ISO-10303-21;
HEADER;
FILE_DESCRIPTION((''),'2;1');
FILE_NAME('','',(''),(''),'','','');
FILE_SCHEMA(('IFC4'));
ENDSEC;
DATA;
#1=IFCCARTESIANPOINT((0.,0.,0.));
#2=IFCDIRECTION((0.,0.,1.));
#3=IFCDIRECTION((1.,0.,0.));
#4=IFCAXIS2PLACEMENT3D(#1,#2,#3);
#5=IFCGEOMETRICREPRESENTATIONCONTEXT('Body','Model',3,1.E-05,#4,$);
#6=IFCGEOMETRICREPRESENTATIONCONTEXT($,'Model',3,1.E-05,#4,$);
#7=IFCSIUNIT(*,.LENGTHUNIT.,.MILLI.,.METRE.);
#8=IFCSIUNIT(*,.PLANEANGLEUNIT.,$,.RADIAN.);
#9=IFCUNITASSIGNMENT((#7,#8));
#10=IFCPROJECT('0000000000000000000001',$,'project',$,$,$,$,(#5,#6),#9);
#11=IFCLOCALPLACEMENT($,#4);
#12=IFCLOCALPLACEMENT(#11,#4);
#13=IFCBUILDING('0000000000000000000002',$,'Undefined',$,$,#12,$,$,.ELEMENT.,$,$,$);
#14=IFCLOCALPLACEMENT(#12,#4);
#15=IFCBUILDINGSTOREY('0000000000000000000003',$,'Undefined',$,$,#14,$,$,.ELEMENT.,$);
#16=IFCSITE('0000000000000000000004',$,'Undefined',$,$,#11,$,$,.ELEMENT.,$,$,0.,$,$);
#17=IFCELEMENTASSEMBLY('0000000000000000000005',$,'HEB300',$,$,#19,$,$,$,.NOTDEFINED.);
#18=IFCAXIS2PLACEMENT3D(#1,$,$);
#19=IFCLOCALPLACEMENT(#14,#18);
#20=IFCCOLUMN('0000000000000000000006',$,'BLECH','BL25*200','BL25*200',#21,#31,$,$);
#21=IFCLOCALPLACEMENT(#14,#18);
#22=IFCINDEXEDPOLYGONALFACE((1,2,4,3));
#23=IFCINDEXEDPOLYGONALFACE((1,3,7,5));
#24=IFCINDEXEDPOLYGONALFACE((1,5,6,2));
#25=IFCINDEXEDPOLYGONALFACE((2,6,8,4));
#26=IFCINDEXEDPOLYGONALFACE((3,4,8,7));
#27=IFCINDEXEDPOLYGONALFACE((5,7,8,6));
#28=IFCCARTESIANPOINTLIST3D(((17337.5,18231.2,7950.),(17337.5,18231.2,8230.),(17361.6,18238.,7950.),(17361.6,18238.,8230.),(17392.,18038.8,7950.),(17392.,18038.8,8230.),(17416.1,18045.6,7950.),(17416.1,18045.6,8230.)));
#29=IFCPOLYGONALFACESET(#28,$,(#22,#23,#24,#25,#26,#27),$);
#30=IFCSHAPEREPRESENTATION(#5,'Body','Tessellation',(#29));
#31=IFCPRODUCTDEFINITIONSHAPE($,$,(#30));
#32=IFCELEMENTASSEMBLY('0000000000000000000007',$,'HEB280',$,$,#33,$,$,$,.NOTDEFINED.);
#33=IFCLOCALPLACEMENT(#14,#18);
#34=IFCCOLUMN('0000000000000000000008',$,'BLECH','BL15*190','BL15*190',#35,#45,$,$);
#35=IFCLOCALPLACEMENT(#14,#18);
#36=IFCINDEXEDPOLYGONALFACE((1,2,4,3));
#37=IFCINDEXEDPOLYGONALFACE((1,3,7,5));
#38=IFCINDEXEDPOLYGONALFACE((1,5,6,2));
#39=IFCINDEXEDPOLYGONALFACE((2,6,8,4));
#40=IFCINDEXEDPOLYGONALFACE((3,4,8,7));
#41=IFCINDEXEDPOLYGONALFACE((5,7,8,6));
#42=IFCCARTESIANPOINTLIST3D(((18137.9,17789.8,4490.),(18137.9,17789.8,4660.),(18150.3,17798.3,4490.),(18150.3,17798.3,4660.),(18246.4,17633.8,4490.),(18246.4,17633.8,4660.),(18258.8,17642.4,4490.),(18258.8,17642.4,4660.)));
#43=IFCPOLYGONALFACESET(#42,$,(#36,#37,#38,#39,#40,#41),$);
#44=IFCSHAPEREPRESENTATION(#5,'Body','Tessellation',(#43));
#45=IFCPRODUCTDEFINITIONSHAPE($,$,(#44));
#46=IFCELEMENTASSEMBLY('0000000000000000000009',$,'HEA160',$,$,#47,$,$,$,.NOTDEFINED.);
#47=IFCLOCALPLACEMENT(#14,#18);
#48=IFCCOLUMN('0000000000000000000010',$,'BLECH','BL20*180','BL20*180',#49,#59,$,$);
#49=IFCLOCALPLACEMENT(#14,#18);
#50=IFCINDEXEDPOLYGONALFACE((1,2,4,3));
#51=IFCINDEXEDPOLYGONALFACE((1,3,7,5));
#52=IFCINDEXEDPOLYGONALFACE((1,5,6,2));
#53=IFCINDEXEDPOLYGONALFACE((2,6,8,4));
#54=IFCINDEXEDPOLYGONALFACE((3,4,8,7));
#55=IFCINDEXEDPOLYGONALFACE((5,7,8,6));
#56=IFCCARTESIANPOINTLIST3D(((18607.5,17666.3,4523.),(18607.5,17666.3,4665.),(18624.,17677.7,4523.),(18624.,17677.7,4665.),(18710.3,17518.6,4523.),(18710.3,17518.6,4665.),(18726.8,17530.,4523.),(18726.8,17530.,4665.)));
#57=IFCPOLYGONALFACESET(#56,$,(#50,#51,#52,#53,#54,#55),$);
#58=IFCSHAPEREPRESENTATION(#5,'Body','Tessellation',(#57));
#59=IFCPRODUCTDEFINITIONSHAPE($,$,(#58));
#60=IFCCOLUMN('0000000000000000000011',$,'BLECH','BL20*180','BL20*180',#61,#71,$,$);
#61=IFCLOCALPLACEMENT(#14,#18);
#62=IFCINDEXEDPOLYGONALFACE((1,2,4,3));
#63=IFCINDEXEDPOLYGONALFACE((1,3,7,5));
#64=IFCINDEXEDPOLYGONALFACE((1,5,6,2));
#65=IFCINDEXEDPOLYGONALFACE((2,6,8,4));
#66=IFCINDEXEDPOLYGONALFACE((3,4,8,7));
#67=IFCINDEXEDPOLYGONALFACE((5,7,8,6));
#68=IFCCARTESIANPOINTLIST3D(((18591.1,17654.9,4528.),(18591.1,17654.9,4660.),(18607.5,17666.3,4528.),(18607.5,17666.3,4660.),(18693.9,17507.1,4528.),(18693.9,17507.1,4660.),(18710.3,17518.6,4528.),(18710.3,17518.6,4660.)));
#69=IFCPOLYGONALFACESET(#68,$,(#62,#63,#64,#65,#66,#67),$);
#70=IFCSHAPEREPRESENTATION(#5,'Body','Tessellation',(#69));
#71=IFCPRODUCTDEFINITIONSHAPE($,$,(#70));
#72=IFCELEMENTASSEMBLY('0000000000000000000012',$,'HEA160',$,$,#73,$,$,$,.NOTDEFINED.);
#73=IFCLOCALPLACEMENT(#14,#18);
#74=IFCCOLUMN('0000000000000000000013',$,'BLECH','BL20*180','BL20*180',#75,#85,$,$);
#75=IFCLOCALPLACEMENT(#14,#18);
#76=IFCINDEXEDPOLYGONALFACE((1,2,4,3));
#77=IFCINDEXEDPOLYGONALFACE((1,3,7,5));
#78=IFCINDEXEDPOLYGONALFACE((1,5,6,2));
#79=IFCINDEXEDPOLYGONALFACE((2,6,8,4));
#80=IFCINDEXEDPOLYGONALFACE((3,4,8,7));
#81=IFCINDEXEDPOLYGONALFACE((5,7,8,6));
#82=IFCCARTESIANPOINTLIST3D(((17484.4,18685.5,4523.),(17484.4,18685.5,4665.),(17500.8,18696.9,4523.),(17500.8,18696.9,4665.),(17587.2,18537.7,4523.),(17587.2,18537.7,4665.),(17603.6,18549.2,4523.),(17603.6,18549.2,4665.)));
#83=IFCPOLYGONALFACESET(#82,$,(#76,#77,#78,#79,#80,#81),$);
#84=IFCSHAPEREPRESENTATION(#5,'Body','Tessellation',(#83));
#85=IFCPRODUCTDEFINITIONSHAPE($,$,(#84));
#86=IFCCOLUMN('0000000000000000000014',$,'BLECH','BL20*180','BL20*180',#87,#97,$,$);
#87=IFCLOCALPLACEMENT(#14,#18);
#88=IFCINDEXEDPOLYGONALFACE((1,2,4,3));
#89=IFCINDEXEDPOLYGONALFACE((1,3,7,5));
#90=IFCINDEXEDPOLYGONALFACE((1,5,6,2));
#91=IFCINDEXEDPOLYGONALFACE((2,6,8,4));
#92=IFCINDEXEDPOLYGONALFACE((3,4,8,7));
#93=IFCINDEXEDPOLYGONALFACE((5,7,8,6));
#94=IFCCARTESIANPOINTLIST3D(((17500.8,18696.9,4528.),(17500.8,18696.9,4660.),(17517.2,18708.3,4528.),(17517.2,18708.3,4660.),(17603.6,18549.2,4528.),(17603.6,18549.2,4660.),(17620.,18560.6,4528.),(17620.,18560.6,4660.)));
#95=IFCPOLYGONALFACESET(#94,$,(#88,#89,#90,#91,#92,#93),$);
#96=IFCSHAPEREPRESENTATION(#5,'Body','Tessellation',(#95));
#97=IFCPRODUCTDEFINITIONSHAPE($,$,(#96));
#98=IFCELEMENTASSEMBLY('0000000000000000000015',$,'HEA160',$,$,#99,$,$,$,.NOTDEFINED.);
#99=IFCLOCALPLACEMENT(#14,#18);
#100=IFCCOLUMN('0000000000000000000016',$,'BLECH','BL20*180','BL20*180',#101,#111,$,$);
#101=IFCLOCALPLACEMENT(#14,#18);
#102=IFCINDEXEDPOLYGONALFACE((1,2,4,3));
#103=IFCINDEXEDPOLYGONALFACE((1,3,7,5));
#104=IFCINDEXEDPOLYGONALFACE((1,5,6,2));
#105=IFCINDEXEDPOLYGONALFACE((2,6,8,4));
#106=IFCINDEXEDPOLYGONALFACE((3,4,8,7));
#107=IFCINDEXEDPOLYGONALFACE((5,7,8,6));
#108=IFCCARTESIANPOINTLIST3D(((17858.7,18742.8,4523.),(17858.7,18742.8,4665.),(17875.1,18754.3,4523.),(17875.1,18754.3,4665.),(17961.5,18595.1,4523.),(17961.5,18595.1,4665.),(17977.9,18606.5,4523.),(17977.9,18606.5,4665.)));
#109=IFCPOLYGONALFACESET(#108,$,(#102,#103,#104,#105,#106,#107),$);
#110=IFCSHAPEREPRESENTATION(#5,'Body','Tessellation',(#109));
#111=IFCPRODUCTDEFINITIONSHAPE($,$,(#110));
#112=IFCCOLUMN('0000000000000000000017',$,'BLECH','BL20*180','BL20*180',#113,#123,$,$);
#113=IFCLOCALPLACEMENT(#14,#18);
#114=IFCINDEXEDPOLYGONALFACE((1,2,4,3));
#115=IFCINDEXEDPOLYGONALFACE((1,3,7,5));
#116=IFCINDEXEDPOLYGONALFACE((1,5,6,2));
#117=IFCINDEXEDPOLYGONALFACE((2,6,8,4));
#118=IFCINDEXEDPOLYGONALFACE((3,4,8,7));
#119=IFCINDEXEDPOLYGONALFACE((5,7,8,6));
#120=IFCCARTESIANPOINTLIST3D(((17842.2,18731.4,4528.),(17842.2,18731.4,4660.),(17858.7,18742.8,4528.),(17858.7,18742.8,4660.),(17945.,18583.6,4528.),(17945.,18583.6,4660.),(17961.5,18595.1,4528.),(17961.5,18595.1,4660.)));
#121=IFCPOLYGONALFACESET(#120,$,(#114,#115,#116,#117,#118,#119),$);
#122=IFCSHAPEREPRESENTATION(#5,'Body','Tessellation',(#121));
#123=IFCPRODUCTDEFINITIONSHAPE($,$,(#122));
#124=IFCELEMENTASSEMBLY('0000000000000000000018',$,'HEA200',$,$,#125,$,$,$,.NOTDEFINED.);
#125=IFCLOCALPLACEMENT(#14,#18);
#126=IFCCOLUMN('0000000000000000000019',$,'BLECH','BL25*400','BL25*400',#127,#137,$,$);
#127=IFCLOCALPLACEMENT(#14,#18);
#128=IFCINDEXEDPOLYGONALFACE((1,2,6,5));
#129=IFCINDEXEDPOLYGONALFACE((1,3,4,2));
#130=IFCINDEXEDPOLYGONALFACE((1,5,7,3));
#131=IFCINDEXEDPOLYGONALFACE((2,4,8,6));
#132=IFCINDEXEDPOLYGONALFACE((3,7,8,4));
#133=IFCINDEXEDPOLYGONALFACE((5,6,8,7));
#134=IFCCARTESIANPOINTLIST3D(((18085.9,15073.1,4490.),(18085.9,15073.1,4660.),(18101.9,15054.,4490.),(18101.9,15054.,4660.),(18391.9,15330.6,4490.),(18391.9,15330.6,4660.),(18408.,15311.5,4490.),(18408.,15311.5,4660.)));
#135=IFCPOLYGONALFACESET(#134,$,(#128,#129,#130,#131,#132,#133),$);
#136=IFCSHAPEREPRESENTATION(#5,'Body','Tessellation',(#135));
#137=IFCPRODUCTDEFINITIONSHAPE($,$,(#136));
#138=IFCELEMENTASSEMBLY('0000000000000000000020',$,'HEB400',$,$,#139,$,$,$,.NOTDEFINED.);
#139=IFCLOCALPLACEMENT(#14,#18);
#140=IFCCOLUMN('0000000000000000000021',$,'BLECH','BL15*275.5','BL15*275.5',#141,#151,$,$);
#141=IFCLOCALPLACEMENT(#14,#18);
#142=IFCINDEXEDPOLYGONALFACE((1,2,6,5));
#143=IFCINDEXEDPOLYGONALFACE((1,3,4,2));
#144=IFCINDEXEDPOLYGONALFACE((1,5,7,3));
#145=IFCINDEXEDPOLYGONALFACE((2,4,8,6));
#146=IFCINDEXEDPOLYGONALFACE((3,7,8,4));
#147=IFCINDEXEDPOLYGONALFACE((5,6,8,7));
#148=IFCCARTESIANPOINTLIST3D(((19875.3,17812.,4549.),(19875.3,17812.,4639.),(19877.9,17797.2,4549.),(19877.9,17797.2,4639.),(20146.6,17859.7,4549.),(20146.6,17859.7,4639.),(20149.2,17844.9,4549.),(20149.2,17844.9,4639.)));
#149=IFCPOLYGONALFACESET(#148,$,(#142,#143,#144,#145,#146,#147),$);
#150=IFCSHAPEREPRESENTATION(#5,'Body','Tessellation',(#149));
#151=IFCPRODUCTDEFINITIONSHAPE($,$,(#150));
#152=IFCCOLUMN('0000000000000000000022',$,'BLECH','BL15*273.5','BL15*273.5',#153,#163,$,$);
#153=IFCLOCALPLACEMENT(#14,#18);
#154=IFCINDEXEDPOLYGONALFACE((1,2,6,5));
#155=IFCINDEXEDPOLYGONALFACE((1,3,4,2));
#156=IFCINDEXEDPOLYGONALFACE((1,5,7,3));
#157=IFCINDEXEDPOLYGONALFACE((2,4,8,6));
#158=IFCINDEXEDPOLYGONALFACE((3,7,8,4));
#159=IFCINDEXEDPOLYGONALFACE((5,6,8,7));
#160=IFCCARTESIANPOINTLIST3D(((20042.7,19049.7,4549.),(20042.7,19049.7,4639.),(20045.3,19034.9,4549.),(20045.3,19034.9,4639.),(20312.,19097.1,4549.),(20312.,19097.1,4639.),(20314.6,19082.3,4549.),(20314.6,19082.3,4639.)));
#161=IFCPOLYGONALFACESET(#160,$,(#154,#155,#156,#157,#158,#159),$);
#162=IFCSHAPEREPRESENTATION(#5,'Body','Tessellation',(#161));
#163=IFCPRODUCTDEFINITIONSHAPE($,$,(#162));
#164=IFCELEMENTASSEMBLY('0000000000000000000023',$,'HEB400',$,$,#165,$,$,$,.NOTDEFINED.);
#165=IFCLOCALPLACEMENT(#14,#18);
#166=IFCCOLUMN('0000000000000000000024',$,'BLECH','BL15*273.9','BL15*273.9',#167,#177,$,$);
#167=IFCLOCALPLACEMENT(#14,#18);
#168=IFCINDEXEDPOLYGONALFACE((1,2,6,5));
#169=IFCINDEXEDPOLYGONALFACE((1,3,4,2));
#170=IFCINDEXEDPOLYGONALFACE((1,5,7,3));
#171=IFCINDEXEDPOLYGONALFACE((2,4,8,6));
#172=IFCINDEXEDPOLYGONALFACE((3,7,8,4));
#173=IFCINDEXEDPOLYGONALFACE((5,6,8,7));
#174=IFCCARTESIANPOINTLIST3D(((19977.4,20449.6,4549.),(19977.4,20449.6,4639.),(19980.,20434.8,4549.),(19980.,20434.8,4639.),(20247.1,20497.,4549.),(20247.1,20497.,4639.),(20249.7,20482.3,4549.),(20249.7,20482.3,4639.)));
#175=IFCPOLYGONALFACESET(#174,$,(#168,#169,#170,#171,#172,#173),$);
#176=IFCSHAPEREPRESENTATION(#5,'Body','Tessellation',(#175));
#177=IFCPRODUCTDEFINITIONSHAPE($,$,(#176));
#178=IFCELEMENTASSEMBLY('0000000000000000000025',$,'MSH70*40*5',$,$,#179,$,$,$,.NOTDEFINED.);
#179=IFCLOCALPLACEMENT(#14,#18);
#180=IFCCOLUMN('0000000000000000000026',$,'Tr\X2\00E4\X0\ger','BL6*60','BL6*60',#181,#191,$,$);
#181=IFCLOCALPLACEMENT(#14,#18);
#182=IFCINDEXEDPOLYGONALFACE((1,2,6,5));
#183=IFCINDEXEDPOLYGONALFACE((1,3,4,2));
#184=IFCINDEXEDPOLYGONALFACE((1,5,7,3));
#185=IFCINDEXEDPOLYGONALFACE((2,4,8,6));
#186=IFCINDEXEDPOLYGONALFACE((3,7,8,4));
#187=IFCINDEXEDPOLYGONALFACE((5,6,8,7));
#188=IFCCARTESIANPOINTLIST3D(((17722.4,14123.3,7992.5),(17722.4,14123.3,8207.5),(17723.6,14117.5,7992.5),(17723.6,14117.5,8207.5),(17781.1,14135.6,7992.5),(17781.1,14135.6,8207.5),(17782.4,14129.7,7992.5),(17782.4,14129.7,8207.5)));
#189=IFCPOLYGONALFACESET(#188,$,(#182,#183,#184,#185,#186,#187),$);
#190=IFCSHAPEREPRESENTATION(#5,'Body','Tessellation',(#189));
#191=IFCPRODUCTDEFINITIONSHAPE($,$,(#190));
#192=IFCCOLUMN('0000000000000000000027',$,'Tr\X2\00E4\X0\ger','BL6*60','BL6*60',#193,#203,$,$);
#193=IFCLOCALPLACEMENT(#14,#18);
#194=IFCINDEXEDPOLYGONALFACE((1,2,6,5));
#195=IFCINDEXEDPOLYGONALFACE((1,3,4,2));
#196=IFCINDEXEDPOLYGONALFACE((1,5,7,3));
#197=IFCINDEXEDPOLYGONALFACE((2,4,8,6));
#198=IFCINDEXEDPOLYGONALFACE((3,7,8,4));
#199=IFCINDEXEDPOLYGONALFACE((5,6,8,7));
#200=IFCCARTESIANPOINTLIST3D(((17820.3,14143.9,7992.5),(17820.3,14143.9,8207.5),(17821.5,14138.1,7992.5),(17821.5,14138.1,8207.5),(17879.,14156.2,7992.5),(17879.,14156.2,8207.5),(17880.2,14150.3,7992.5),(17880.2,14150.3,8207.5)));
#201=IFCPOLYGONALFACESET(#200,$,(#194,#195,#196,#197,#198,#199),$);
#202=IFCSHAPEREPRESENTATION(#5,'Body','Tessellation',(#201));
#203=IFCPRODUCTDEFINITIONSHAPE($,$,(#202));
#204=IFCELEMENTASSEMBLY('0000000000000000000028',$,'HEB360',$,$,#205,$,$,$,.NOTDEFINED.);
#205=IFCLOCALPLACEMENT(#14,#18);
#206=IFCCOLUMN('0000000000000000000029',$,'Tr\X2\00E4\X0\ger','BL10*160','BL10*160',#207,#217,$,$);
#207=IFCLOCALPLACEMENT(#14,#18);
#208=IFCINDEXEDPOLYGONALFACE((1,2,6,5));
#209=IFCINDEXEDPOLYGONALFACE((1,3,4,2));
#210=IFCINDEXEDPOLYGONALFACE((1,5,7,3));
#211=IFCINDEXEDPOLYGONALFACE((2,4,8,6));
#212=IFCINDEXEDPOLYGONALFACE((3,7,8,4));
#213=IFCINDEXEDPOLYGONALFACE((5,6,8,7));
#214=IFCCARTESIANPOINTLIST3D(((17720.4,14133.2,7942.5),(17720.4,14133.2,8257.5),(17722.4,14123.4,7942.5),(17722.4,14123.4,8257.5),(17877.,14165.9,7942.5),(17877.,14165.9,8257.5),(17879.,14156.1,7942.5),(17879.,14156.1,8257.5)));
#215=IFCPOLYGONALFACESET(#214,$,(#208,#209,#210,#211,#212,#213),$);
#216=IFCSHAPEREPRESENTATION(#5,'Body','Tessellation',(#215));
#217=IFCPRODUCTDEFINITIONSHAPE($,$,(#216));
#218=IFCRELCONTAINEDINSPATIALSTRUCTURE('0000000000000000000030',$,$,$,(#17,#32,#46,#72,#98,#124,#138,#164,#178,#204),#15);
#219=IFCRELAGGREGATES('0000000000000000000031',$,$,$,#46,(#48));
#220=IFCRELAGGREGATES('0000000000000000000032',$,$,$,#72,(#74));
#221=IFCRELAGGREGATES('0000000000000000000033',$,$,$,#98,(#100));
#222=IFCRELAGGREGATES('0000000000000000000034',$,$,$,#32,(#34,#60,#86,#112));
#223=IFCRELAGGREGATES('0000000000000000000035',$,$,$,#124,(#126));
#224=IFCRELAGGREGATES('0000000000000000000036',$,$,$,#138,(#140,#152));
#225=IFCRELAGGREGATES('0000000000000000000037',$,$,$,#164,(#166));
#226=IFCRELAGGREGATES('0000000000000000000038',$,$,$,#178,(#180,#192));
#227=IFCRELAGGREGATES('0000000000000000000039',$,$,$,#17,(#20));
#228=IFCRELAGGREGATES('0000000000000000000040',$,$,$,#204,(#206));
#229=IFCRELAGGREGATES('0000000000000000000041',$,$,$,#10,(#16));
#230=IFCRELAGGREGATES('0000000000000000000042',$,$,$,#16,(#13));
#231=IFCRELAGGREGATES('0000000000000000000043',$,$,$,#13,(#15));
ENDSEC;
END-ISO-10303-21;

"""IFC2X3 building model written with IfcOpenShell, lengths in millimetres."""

from ifc_helpers import new_model, si_unit, frame, origin_with_axes, origin_2d_with_axis, place, context, project, spatial, rectangle, extrude, element, aggregate, save


model = new_model("IFC2X3")

# Units and contexts
model_context_1 = context("Model", 3, precision=1e-05, world=origin_with_axes(), identifier="Body")
model_context_2 = context("Model", 3, precision=1e-05, world=origin_with_axes())
ifc_project = project(units=[si_unit("LENGTHUNIT", "METRE", prefix="MILLI"), si_unit("PLANEANGLEUNIT", "RADIAN")], contexts=[model_context_1, model_context_2])

# Site, building, storey
site_placement = place(None, origin_with_axes())
site = spatial("IfcSite", under=ifc_project, at=site_placement, Name="Undefined", CompositionType="ELEMENT", RefElevation=0.0)
building_placement = place(site_placement, origin_with_axes())
building = spatial("IfcBuilding", under=site, at=building_placement, Name="Undefined", CompositionType="ELEMENT")
storey_placement = place(building_placement, origin_with_axes())
storey = spatial("IfcBuildingStorey", under=building, at=storey_placement, Name="Undefined", CompositionType="ELEMENT")

# Element assemblies, columns
assembly_1 = element("IfcElementAssembly", 1, inside=storey, Name="HEB300", PredefinedType="NOTDEFINED")
column_1_placement = place(storey_placement, frame((17376.8, 18138.4, 7950.0), z_axis=(0.0, 0.0, 1.0), x_axis=(1.0, 0.0, 0.0)))
column_1 = element("IfcColumn", 2, at=column_1_placement, Name="BLECH", Description="BL25*200", ObjectType="BL25*200", context=model_context_1, shape_type="SweptSolid", body=[
    extrude(rectangle(XDim=25.0, YDim=200.0, at=origin_2d_with_axis()), frame((0.0, 0.0, 280.0), z_axis=(0.0, 0.0, -1.0), x_axis=(0.96217, 0.272448, 0.0)), (0.0, 0.0, 1.0), 280.0),
])
assembly_2 = element("IfcElementAssembly", 3, inside=storey, Name="HEB280", PredefinedType="NOTDEFINED")
column_2_placement = place(storey_placement, frame((18198.4, 17716.1, 4490.0), z_axis=(0.0, 0.0, 1.0), x_axis=(1.0, 0.0, 0.0)))
column_2 = element("IfcColumn", 4, at=column_2_placement, Name="BLECH", Description="BL15*190", ObjectType="BL15*190", context=model_context_1, shape_type="SweptSolid", body=[
    extrude(rectangle(XDim=15.0, YDim=190.0, at=origin_2d_with_axis()), frame((0.0, 0.0, 170.0), z_axis=(0.0, 0.0, -1.0), x_axis=(-0.820902, -0.571069, 0.0)), (0.0, 0.0, 1.0), 170.0),
])
assembly_3 = element("IfcElementAssembly", 5, inside=storey, Name="HEA160", PredefinedType="NOTDEFINED")
column_3_placement = place(storey_placement, frame((18667.2, 17598.2, 4523.0), z_axis=(0.0, 0.0, 1.0), x_axis=(1.0, 0.0, 0.0)))
column_3 = element("IfcColumn", 6, at=column_3_placement, Name="BLECH", Description="BL20*180", ObjectType="BL20*180", context=model_context_1, shape_type="SweptSolid", body=[
    extrude(rectangle(XDim=20.0, YDim=180.0, at=origin_2d_with_axis()), frame((0.0, 0.0, 142.0), z_axis=(0.0, 0.0, -1.0), x_axis=(0.820902, 0.571069, 0.0)), (0.0, 0.0, 1.0), 142.0),
])
aggregate(assembly_3, [column_3])

# Column
column_4_placement = place(storey_placement, frame((18650.7, 17586.7, 4528.0), z_axis=(0.0, 0.0, 1.0), x_axis=(1.0, 0.0, 0.0)))
column_4 = element("IfcColumn", 7, at=column_4_placement, Name="BLECH", Description="BL20*180", ObjectType="BL20*180", context=model_context_1, shape_type="SweptSolid", body=[
    extrude(rectangle(XDim=20.0, YDim=180.0, at=origin_2d_with_axis()), frame((0.0, 0.0, 132.0), z_axis=(0.0, 0.0, -1.0), x_axis=(0.820902, 0.571069, 0.0)), (0.0, 0.0, 1.0), 132.0),
])

# Element assembly, column
assembly_4 = element("IfcElementAssembly", 8, inside=storey, Name="HEA160", PredefinedType="NOTDEFINED")
column_5_placement = place(storey_placement, frame((17544.0, 18617.3, 4523.0), z_axis=(0.0, 0.0, 1.0), x_axis=(1.0, 0.0, 0.0)))
column_5 = element("IfcColumn", 9, at=column_5_placement, Name="BLECH", Description="BL20*180", ObjectType="BL20*180", context=model_context_1, shape_type="SweptSolid", body=[
    extrude(rectangle(XDim=20.0, YDim=180.0, at=origin_2d_with_axis()), frame((0.0, 0.0, 142.0), z_axis=(0.0, 0.0, -1.0), x_axis=(-0.820902, -0.571069, 0.0)), (0.0, 0.0, 1.0), 142.0),
])
aggregate(assembly_4, [column_5])

# Column
column_6_placement = place(storey_placement, frame((17560.4, 18628.8, 4528.0), z_axis=(0.0, 0.0, 1.0), x_axis=(1.0, 0.0, 0.0)))
column_6 = element("IfcColumn", 10, at=column_6_placement, Name="BLECH", Description="BL20*180", ObjectType="BL20*180", context=model_context_1, shape_type="SweptSolid", body=[
    extrude(rectangle(XDim=20.0, YDim=180.0, at=origin_2d_with_axis()), frame((0.0, 0.0, 132.0), z_axis=(0.0, 0.0, -1.0), x_axis=(-0.820902, -0.571069, 0.0)), (0.0, 0.0, 1.0), 132.0),
])

# Element assembly, column
assembly_5 = element("IfcElementAssembly", 11, inside=storey, Name="HEA160", PredefinedType="NOTDEFINED")
column_7_placement = place(storey_placement, frame((17918.3, 18674.7, 4523.0), z_axis=(0.0, 0.0, 1.0), x_axis=(1.0, 0.0, 0.0)))
column_7 = element("IfcColumn", 12, at=column_7_placement, Name="BLECH", Description="BL20*180", ObjectType="BL20*180", context=model_context_1, shape_type="SweptSolid", body=[
    extrude(rectangle(XDim=20.0, YDim=180.0, at=origin_2d_with_axis()), frame((0.0, 0.0, 142.0), z_axis=(0.0, 0.0, -1.0), x_axis=(0.820902, 0.571069, 0.0)), (0.0, 0.0, 1.0), 142.0),
])
aggregate(assembly_5, [column_7])

# Column
column_8_placement = place(storey_placement, frame((17901.9, 18663.2, 4528.0), z_axis=(0.0, 0.0, 1.0), x_axis=(1.0, 0.0, 0.0)))
column_8 = element("IfcColumn", 13, at=column_8_placement, Name="BLECH", Description="BL20*180", ObjectType="BL20*180", context=model_context_1, shape_type="SweptSolid", body=[
    extrude(rectangle(XDim=20.0, YDim=180.0, at=origin_2d_with_axis()), frame((0.0, 0.0, 132.0), z_axis=(0.0, 0.0, -1.0), x_axis=(0.820902, 0.571069, 0.0)), (0.0, 0.0, 1.0), 132.0),
])
aggregate(assembly_2, [column_2, column_4, column_6, column_8])

# Element assembly, column
assembly_6 = element("IfcElementAssembly", 14, inside=storey, Name="HEA200", PredefinedType="NOTDEFINED")
column_9_placement = place(storey_placement, frame((18246.9, 15192.3, 4490.0), z_axis=(0.0, 0.0, 1.0), x_axis=(1.0, 0.0, 0.0)))
column_9 = element("IfcColumn", 15, at=column_9_placement, Name="BLECH", Description="BL25*400", ObjectType="BL25*400", context=model_context_1, shape_type="SweptSolid", body=[
    extrude(rectangle(XDim=25.0, YDim=400.0, at=origin_2d_with_axis()), frame((0.0, 0.0, 170.0), z_axis=(0.0, 0.0, -1.0), x_axis=(-0.643784, 0.765207, 0.0)), (0.0, 0.0, 1.0), 170.0),
])
aggregate(assembly_6, [column_9])

# Element assembly, columns
assembly_7 = element("IfcElementAssembly", 16, inside=storey, Name="HEB400", PredefinedType="NOTDEFINED")
column_10_placement = place(storey_placement, frame((20012.2, 17828.5, 4549.0), z_axis=(0.0, 0.0, 1.0), x_axis=(1.0, 0.0, 0.0)))
column_10 = element("IfcColumn", 17, at=column_10_placement, Name="BLECH", Description="BL15*275.5", ObjectType="BL15*275.5", context=model_context_1, shape_type="SweptSolid", body=[
    extrude(rectangle(XDim=15.0, YDim=275.5, at=origin_2d_with_axis()), frame((0.0, 0.0, 90.0), z_axis=(0.0, 0.0, -1.0), x_axis=(-0.173304, 0.984868, 0.0)), (0.0, 0.0, 1.0), 90.0),
])
column_11_placement = place(storey_placement, frame((20178.6, 19066.0, 4549.0), z_axis=(0.0, 0.0, 1.0), x_axis=(1.0, 0.0, 0.0)))
column_11 = element("IfcColumn", 18, at=column_11_placement, Name="BLECH", Description="BL15*273.5", ObjectType="BL15*273.5", context=model_context_1, shape_type="SweptSolid", body=[
    extrude(rectangle(XDim=15.0, YDim=273.5, at=origin_2d_with_axis()), frame((0.0, 0.0, 90.0), z_axis=(0.0, 0.0, -1.0), x_axis=(-0.173304, 0.984868, 0.0)), (0.0, 0.0, 1.0), 90.0),
])
aggregate(assembly_7, [column_10, column_11])

# Element assembly, column
assembly_8 = element("IfcElementAssembly", 19, inside=storey, Name="HEB400", PredefinedType="NOTDEFINED")
column_12_placement = place(storey_placement, frame((20113.6, 20465.9, 4549.0), z_axis=(0.0, 0.0, 1.0), x_axis=(1.0, 0.0, 0.0)))
column_12 = element("IfcColumn", 20, at=column_12_placement, Name="BLECH", Description="BL15*273.9", ObjectType="BL15*273.9", context=model_context_1, shape_type="SweptSolid", body=[
    extrude(rectangle(XDim=15.0, YDim=273.9, at=origin_2d_with_axis()), frame((0.0, 0.0, 90.0), z_axis=(0.0, 0.0, -1.0), x_axis=(-0.173304, 0.984868, 0.0)), (0.0, 0.0, 1.0), 90.0),
])
aggregate(assembly_8, [column_12])

# Element assembly, columns
assembly_9 = element("IfcElementAssembly", 21, inside=storey, Name="MSH70*40*5", PredefinedType="NOTDEFINED")
column_13_placement = place(storey_placement, frame((17752.4, 14126.5, 7992.5), z_axis=(0.0, 0.0, 1.0), x_axis=(1.0, 0.0, 0.0)))
column_13 = element("IfcColumn", 22, at=column_13_placement, Name="Träger", Description="BL6*60", ObjectType="BL6*60", context=model_context_1, shape_type="SweptSolid", body=[
    extrude(rectangle(XDim=6.0, YDim=60.0, at=origin_2d_with_axis()), frame((0.0, 0.0, 215.0), z_axis=(0.0, 0.0, -1.0), x_axis=(0.204496, -0.978867, 0.0)), (0.0, 0.0, 1.0), 215.0),
])
column_14_placement = place(storey_placement, frame((17850.2, 14147.1, 7992.5), z_axis=(0.0, 0.0, 1.0), x_axis=(1.0, 0.0, 0.0)))
column_14 = element("IfcColumn", 23, at=column_14_placement, Name="Träger", Description="BL6*60", ObjectType="BL6*60", context=model_context_1, shape_type="SweptSolid", body=[
    extrude(rectangle(XDim=6.0, YDim=60.0, at=origin_2d_with_axis()), frame((0.0, 0.0, 215.0), z_axis=(0.0, 0.0, -1.0), x_axis=(0.204496, -0.978867, 0.0)), (0.0, 0.0, 1.0), 215.0),
])

# Element assembly, column
assembly_10 = element("IfcElementAssembly", 24, inside=storey, Name="HEB360", PredefinedType="NOTDEFINED")
column_15_placement = place(storey_placement, frame((17799.7, 14144.7, 7942.5), z_axis=(0.0, 0.0, 1.0), x_axis=(1.0, 0.0, 0.0)))
column_15 = element("IfcColumn", 25, at=column_15_placement, Name="Träger", Description="BL10*160", ObjectType="BL10*160", context=model_context_1, shape_type="SweptSolid", body=[
    extrude(rectangle(XDim=10.0, YDim=160.0, at=origin_2d_with_axis()), frame((0.0, 0.0, 315.0), z_axis=(0.0, 0.0, -1.0), x_axis=(0.204496, -0.978867, 0.0)), (0.0, 0.0, 1.0), 315.0),
])

aggregate(assembly_9, [column_13, column_14])
aggregate(assembly_1, [column_1])
aggregate(assembly_10, [column_15])

save(model, "model.ifc")
